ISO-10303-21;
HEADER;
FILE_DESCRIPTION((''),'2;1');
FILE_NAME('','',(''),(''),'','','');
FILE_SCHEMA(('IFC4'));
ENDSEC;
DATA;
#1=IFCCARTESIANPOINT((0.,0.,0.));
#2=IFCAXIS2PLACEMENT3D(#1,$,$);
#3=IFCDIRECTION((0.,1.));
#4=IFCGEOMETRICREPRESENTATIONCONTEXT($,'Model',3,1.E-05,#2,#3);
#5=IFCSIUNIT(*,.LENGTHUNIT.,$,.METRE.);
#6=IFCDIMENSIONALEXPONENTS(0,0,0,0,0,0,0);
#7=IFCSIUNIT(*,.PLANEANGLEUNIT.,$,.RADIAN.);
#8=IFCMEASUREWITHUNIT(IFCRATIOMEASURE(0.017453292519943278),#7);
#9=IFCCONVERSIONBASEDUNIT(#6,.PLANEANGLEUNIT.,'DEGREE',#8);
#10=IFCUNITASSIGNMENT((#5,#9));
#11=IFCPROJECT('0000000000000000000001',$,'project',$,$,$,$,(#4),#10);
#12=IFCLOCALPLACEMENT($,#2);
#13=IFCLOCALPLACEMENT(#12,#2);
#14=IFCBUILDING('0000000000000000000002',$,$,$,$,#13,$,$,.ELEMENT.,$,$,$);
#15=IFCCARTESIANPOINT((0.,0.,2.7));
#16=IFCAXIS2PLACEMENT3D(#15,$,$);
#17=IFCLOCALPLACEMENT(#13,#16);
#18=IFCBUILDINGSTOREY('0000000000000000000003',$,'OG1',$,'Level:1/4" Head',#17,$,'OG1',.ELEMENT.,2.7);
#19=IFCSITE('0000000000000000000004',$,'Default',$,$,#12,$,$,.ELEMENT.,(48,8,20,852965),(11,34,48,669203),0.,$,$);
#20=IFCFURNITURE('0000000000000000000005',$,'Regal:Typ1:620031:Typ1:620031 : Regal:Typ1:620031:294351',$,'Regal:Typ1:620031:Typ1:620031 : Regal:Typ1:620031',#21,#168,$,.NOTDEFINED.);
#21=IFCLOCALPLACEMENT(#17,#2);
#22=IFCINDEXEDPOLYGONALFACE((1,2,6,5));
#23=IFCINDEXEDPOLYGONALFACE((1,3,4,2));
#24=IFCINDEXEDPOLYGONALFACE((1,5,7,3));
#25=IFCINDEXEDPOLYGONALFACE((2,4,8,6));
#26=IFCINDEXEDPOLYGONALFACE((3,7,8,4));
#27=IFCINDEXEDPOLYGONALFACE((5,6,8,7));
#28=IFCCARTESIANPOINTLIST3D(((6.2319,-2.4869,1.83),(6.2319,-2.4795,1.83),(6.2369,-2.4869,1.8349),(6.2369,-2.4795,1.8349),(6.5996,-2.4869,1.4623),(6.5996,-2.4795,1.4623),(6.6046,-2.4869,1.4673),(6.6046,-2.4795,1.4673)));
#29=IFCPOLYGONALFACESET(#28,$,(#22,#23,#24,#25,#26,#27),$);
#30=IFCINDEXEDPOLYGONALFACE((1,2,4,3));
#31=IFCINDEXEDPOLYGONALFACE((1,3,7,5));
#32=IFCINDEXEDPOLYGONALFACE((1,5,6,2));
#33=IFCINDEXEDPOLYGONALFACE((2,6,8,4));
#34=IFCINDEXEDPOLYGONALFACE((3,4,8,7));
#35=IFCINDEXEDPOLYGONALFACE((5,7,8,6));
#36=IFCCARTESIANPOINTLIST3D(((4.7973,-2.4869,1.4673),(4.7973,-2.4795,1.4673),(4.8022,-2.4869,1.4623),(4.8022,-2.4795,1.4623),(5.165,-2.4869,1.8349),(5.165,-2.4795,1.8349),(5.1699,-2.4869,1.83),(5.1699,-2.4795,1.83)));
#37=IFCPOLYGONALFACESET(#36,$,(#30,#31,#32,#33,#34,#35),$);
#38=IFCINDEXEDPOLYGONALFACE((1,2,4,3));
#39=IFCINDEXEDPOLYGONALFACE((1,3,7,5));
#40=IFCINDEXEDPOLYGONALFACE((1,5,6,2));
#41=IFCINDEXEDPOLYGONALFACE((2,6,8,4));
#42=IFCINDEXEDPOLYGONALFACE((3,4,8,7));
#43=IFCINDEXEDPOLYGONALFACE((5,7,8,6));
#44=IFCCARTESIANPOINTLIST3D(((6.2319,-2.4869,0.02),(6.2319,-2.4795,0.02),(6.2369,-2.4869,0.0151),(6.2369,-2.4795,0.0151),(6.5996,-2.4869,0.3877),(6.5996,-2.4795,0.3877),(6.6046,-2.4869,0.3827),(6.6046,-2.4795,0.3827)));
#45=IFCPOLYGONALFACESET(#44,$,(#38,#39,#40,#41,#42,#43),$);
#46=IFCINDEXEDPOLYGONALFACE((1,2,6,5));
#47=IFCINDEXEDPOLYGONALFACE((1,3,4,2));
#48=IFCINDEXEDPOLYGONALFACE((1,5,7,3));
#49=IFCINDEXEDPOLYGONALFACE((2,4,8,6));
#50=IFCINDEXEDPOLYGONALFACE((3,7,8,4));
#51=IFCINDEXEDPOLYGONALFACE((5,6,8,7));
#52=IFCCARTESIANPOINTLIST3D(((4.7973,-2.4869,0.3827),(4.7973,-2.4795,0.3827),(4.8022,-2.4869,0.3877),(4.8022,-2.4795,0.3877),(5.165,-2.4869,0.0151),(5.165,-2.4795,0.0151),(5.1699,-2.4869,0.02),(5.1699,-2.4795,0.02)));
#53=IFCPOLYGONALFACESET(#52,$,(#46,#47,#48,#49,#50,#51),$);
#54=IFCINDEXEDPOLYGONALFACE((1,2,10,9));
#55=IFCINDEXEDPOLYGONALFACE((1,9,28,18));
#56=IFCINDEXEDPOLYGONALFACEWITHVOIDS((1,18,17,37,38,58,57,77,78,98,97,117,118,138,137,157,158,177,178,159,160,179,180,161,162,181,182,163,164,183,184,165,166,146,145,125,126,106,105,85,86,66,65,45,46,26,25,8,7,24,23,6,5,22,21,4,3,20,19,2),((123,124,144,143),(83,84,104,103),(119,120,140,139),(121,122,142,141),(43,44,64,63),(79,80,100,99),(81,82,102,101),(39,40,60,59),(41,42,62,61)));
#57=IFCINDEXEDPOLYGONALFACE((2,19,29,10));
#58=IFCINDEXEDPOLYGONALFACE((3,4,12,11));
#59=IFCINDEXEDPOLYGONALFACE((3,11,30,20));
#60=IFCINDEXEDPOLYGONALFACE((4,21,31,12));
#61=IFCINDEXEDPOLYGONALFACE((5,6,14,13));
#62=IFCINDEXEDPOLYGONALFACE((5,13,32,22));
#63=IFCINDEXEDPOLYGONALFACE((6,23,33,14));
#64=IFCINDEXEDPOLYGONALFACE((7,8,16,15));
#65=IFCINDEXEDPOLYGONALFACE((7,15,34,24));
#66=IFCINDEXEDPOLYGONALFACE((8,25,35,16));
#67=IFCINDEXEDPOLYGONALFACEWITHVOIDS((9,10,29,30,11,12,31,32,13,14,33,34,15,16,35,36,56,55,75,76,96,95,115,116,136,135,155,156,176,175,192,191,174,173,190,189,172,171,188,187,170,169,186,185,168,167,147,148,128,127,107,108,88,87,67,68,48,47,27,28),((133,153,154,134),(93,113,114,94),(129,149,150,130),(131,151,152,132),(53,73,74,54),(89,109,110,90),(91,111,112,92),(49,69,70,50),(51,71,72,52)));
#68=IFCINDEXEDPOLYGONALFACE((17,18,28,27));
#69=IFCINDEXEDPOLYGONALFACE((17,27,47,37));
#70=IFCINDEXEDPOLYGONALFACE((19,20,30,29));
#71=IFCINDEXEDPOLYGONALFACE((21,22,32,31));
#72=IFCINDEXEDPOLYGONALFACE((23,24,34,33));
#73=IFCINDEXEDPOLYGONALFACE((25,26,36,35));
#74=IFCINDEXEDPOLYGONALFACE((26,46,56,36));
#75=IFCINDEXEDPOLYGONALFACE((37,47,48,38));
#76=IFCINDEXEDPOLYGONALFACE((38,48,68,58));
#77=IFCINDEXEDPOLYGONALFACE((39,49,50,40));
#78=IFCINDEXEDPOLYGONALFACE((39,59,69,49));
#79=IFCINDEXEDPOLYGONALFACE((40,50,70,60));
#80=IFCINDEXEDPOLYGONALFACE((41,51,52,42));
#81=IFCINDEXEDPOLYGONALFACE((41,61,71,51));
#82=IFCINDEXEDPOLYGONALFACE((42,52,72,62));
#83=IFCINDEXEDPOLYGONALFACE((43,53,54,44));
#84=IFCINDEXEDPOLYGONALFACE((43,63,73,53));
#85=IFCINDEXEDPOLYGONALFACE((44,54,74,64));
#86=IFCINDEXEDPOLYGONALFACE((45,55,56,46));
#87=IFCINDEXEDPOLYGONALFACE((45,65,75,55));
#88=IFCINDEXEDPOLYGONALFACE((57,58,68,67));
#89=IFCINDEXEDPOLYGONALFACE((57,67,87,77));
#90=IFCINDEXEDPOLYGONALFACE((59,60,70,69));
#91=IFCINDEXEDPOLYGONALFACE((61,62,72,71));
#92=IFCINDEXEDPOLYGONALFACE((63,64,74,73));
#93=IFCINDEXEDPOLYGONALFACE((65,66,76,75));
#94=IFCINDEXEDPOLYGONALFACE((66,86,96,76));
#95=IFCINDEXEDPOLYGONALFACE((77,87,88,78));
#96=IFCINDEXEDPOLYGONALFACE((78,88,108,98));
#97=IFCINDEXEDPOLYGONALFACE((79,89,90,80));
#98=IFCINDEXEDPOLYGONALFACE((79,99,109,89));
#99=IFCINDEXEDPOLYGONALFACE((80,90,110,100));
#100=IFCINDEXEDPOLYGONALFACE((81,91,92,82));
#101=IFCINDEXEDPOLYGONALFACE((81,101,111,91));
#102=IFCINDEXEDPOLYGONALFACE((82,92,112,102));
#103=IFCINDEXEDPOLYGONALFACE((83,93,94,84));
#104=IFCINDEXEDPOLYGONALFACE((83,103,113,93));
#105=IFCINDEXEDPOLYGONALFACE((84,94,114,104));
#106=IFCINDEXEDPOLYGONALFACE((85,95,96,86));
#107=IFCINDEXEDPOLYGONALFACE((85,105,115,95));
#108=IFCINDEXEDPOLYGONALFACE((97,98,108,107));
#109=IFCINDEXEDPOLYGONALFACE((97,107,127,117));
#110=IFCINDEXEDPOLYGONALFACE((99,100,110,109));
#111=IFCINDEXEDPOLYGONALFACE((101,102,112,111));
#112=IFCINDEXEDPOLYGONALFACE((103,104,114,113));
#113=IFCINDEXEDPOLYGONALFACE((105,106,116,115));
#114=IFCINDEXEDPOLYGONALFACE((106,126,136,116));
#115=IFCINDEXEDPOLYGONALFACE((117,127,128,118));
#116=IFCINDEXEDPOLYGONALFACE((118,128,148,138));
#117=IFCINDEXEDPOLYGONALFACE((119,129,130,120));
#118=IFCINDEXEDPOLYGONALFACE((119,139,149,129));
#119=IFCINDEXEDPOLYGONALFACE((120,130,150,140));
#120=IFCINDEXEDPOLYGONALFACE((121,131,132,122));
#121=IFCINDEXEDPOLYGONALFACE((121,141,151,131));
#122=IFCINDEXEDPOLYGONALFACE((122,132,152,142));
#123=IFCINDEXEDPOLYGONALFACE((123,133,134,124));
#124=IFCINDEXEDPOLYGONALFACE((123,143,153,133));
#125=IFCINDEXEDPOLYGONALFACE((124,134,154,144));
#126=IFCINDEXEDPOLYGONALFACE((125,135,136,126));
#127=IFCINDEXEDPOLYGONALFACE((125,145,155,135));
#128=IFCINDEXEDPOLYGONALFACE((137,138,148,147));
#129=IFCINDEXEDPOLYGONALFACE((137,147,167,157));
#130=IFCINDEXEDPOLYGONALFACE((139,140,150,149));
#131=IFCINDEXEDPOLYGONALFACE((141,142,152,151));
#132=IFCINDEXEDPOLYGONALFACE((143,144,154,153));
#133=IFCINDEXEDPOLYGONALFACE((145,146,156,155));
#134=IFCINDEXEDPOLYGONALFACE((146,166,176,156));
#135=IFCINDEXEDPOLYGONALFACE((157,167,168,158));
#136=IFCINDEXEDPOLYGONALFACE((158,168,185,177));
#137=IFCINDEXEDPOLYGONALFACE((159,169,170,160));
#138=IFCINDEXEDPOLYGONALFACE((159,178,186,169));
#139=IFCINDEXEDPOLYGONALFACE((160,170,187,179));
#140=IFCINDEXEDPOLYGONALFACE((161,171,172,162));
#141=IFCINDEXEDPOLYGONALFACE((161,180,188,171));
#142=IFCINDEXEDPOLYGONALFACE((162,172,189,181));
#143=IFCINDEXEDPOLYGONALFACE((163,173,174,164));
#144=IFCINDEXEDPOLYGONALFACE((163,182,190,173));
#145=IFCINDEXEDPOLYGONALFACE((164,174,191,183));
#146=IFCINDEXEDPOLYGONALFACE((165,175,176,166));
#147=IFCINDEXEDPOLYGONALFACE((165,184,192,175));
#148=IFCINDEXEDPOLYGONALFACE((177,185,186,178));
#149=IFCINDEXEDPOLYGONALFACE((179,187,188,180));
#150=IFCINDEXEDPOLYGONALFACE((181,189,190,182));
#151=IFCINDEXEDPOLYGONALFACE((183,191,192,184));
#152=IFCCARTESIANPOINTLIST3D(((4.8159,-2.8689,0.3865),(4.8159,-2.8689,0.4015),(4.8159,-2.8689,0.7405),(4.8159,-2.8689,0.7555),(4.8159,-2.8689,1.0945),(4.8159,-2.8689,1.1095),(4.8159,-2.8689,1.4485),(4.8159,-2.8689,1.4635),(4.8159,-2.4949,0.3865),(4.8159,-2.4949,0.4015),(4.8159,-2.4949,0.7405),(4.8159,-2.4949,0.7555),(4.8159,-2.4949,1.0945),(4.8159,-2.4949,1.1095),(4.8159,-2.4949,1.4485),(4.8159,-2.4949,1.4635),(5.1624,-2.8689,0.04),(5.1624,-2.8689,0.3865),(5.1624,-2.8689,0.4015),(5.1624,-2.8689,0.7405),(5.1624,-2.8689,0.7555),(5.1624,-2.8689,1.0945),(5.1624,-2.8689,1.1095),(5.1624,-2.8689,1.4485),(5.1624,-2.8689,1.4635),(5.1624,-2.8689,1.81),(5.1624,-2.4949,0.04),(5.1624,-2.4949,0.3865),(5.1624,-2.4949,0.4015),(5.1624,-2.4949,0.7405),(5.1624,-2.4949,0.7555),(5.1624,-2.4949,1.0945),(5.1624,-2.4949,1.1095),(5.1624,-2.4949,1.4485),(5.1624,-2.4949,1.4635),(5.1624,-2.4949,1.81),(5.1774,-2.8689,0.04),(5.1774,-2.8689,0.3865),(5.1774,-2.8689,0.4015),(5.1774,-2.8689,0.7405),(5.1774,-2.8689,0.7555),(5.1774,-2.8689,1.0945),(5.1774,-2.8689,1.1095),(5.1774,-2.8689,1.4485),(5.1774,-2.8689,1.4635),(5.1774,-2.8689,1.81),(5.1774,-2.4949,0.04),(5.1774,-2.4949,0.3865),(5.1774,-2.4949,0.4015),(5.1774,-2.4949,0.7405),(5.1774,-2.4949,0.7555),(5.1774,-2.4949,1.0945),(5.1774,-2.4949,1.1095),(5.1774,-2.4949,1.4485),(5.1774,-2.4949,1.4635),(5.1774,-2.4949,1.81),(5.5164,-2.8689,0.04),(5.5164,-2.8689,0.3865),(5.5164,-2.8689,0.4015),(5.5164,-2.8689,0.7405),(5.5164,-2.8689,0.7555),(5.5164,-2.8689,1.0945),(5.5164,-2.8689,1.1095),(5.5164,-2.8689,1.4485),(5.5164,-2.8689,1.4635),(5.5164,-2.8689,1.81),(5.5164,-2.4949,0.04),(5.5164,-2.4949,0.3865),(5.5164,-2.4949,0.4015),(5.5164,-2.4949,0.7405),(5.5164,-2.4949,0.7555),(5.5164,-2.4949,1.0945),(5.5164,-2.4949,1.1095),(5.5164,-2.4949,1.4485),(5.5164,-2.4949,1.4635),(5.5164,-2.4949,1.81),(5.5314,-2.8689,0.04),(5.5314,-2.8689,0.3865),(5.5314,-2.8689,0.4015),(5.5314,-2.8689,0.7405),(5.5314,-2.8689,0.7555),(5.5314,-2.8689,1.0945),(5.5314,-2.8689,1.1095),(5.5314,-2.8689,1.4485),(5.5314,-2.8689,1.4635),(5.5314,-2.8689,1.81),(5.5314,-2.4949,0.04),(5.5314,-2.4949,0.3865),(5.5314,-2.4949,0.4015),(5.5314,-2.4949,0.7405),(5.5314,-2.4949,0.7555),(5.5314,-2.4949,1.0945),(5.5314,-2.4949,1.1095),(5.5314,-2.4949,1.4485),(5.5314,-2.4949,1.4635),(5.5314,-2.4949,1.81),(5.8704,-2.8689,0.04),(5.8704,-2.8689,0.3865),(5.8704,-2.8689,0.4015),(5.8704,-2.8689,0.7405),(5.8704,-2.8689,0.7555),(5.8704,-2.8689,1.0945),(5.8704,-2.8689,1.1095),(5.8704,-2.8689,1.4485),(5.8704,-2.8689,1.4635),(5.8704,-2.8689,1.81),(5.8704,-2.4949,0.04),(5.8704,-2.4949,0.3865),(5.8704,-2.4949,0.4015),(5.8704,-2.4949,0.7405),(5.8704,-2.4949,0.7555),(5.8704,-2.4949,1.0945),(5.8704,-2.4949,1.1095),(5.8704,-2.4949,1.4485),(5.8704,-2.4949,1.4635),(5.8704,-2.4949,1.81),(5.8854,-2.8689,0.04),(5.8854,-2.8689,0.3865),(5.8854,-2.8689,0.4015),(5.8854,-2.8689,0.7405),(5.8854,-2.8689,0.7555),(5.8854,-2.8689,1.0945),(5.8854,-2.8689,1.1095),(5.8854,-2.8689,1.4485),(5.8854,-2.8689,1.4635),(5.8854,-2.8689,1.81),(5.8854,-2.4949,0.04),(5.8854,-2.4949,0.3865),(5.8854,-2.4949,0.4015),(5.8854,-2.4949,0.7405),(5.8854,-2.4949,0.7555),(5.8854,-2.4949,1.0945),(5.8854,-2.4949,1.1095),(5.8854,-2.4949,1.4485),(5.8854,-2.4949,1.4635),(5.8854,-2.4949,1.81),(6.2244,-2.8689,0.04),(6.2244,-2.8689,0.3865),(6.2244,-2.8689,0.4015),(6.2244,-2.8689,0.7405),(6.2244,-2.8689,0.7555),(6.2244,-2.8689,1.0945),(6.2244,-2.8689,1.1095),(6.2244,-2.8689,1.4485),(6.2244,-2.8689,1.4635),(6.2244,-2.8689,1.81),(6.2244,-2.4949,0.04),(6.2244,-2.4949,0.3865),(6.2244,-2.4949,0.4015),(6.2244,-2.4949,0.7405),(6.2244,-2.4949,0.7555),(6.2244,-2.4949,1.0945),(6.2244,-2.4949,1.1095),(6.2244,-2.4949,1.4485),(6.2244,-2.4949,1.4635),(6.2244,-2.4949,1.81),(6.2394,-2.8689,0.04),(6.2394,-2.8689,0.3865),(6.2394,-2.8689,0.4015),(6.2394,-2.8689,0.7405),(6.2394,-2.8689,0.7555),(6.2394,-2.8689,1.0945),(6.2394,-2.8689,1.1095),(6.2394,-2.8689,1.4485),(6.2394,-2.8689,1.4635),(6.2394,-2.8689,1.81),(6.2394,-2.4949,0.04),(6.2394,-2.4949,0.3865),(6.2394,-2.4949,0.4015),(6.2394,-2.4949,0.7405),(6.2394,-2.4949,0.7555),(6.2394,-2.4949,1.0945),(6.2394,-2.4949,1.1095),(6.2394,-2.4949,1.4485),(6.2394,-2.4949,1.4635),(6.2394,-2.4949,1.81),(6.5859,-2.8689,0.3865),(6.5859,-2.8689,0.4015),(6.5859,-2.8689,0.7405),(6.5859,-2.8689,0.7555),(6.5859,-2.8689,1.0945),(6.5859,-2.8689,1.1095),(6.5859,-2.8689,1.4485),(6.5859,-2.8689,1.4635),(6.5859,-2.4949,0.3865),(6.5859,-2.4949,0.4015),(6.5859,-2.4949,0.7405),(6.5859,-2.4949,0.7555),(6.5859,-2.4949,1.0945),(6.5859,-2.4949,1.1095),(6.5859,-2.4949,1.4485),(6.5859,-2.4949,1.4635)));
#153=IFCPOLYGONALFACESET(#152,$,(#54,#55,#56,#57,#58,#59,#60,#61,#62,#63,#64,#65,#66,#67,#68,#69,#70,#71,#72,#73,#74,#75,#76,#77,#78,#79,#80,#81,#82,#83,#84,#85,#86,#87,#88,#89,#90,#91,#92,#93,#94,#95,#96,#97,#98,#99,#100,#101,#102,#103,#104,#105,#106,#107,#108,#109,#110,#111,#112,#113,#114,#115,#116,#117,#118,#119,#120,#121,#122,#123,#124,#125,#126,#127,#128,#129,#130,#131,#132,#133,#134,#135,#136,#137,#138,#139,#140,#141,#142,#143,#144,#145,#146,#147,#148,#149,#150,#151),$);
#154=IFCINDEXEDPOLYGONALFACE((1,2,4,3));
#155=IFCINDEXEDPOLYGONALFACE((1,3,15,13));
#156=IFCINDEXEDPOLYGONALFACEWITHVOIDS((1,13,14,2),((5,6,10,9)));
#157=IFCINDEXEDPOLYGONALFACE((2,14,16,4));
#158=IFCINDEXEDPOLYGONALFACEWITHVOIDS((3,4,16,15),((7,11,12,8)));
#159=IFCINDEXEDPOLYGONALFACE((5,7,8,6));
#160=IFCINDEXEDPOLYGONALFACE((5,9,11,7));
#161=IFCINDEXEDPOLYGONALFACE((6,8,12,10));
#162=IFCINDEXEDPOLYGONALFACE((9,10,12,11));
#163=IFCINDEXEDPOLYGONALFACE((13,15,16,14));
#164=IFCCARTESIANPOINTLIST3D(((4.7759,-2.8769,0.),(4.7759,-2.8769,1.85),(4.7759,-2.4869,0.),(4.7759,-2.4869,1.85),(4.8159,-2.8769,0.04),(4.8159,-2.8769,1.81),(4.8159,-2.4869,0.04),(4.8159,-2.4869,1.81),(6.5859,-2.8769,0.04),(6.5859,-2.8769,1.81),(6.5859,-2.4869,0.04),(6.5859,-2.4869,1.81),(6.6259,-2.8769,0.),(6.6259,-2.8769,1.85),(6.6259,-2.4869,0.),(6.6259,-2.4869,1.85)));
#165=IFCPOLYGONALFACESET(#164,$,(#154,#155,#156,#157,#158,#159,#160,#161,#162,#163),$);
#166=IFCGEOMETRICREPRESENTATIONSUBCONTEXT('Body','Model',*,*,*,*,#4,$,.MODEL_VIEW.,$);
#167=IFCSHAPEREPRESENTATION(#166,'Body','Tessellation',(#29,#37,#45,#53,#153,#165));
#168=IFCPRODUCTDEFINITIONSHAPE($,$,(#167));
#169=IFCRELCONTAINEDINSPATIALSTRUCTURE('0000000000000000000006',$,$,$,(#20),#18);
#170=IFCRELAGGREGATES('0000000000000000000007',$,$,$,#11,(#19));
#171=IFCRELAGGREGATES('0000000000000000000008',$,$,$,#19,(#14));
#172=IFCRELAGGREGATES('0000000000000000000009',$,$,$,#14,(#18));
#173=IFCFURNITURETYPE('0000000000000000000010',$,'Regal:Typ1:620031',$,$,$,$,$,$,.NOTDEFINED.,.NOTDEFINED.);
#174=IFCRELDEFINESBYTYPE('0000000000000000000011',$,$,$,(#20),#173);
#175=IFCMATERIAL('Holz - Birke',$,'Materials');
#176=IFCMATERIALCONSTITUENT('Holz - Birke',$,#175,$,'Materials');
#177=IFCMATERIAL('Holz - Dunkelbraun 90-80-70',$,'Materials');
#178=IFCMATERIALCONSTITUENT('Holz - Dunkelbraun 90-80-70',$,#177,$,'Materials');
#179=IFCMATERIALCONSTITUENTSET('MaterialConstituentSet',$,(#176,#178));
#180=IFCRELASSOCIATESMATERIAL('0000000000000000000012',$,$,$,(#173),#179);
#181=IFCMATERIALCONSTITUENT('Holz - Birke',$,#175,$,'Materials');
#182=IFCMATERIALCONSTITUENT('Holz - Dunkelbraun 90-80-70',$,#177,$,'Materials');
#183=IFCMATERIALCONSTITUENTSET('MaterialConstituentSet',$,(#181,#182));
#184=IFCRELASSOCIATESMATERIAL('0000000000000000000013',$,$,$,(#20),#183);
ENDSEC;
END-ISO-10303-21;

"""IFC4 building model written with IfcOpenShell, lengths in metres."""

from ifc_helpers import new_model, entity, si_unit, converted_unit, direction, frame, origin, place, context, subcontext, project, spatial, indexed_curve, outline, extrude, source, transform, mapped, material, constituent, constituent_set, type_object, type_shapes, element, save


model = new_model("IFC4")

# Units and contexts
model_context = context("Model", 3, precision=1e-05, world=origin(), true_north=direction((0.0, 1.0)))
body_context = subcontext(model_context, "Body", "Model", "MODEL_VIEW")
ifc_project = project(units=[si_unit("LENGTHUNIT", "METRE"), converted_unit("PLANEANGLEUNIT", "DEGREE", entity("IfcRatioMeasure", 0.017453292519943278), si_unit("PLANEANGLEUNIT", "RADIAN"), dimensions=[0, 0, 0, 0, 0, 0, 0])], contexts=[model_context])

# Site, building, storey
site_placement = place(None, origin())
site = spatial("IfcSite", under=ifc_project, at=site_placement, Name="Default", CompositionType="ELEMENT", RefLatitude=(48, 8, 20, 852965), RefLongitude=(11, 34, 48, 669203), RefElevation=0.0)
building_placement = place(site_placement, origin())
building = spatial("IfcBuilding", under=site, at=building_placement, CompositionType="ELEMENT")
storey_placement = place(building_placement, frame((0.0, 0.0, 2.7)))
storey = spatial("IfcBuildingStorey", under=building, at=storey_placement, Name="OG1", ObjectType="Level:1/4\" Head", LongName="OG1", CompositionType="ELEMENT", Elevation=2.7)

# Shared definitions
ifc_material_1 = material(Name="Holz - Birke", Category="Materials")

# Furniture
ifc_material_2 = material(Name="Holz - Dunkelbraun 90-80-70", Category="Materials")
ifc_constituent_1 = constituent(ifc_material_1, Name="Holz - Birke", Category="Materials")
ifc_constituent_2 = constituent(ifc_material_2, Name="Holz - Dunkelbraun 90-80-70", Category="Materials")
ifc_constituent_set_1 = constituent_set(constituents=[ifc_constituent_1, ifc_constituent_2], Name="MaterialConstituentSet")
ifc_constituent_3 = constituent(ifc_material_1, Name="Holz - Birke", Category="Materials")
ifc_constituent_4 = constituent(ifc_material_2, Name="Holz - Dunkelbraun 90-80-70", Category="Materials")
ifc_constituent_set_2 = constituent_set(constituents=[ifc_constituent_3, ifc_constituent_4], Name="MaterialConstituentSet")
furniture_type_1 = type_object("IfcFurnitureType", Name="Regal:Typ1:620031", AssemblyPlace="NOTDEFINED", PredefinedType="NOTDEFINED", material=ifc_constituent_set_2)
shared_shape_1 = source(origin(), body_context, "Body", "SweptSolid", [
    extrude(outline(indexed_curve([(-0.0035, -0.0037), (0.0035, -0.0037), (0.0035, 0.0037), (-0.0035, 0.0037), (-0.0035, -0.0037)], self_intersect=False)), frame((6.6021, -2.4832, 4.1648), z_axis=(-0.707107, 0.0, 0.707107), x_axis=(-0.707107, 0.0, -0.707107)), (0.0, 0.0, 1.0), 0.52),
    extrude(outline(indexed_curve([(-0.0035, -0.0037), (0.0035, -0.0037), (0.0035, 0.0037), (-0.0035, 0.0037), (-0.0035, -0.0037)], self_intersect=False)), frame((4.7998, -2.4832, 4.1648), z_axis=(0.707107, 0.0, 0.707107), x_axis=(-0.707107, 0.0, 0.707107)), (0.0, 0.0, 1.0), 0.52),
    extrude(outline(indexed_curve([(-0.0035, -0.0037), (0.0035, -0.0037), (0.0035, 0.0037), (-0.0035, 0.0037), (-0.0035, -0.0037)], self_intersect=False)), frame((6.2344, -2.4832, 2.7175), z_axis=(0.707107, 0.0, 0.707107), x_axis=(-0.707107, 0.0, 0.707107)), (0.0, 0.0, 1.0), 0.52),
    extrude(outline(indexed_curve([(-0.0035, -0.0037), (0.0035, -0.0037), (0.0035, 0.0037), (-0.0035, 0.0037), (-0.0035, -0.0037)], self_intersect=False)), frame((5.1675, -2.4832, 2.7175), z_axis=(-0.707107, 0.0, 0.707107), x_axis=(-0.707107, 0.0, -0.707107)), (0.0, 0.0, 1.0), 0.52),
    extrude(outline(indexed_curve([(-0.5385, -0.885), (-0.5235, -0.885), (-0.5235, -0.5385), (-0.1845, -0.5385), (-0.1845, -0.885), (-0.1695, -0.885), (-0.1695, -0.5385), (0.1695, -0.5385), (0.1695, -0.885), (0.1845, -0.885), (0.1845, -0.5385), (0.5235, -0.5385), (0.5235, -0.885), (0.5385, -0.885), (0.5385, -0.5385), (0.885, -0.5385), (0.885, -0.5235), (0.5385, -0.5235), (0.5385, -0.1845), (0.885, -0.1845), (0.885, -0.1695), (0.5385, -0.1695), (0.5385, 0.1695), (0.885, 0.1695), (0.885, 0.1845), (0.5385, 0.1845), (0.5385, 0.5235), (0.885, 0.5235), (0.885, 0.5385), (0.5385, 0.5385), (0.5385, 0.885), (0.5235, 0.885), (0.5235, 0.5385), (0.1845, 0.5385), (0.1845, 0.885), (0.1695, 0.885), (0.1695, 0.5385), (-0.1695, 0.5385), (-0.1695, 0.885), (-0.1845, 0.885), (-0.1845, 0.5385), (-0.5235, 0.5385), (-0.5235, 0.885), (-0.5385, 0.885), (-0.5385, 0.5385), (-0.885, 0.5385), (-0.885, 0.5235), (-0.5385, 0.5235), (-0.5385, 0.1845), (-0.885, 0.1845), (-0.885, 0.1695), (-0.5385, 0.1695), (-0.5385, -0.1695), (-0.885, -0.1695), (-0.885, -0.1845), (-0.5385, -0.1845), (-0.5385, -0.5235), (-0.885, -0.5235), (-0.885, -0.5385), (-0.5385, -0.5385), (-0.5385, -0.885)], self_intersect=False), holes=[indexed_curve([(-0.5235, -0.5235), (-0.5235, -0.1845), (-0.1845, -0.1845), (-0.1845, -0.5235), (-0.5235, -0.5235)], self_intersect=False), indexed_curve([(0.1695, -0.1845), (0.1695, -0.5235), (-0.1695, -0.5235), (-0.1695, -0.1845), (0.1695, -0.1845)], self_intersect=False), indexed_curve([(0.5235, -0.1845), (0.5235, -0.5235), (0.1845, -0.5235), (0.1845, -0.1845), (0.5235, -0.1845)], self_intersect=False), indexed_curve([(0.5235, -0.1695), (0.1845, -0.1695), (0.1845, 0.1695), (0.5235, 0.1695), (0.5235, -0.1695)], self_intersect=False), indexed_curve([(0.1695, -0.1695), (-0.1695, -0.1695), (-0.1695, 0.1695), (0.1695, 0.1695), (0.1695, -0.1695)], self_intersect=False), indexed_curve([(-0.1845, -0.1695), (-0.5235, -0.1695), (-0.5235, 0.1695), (-0.1845, 0.1695), (-0.1845, -0.1695)], self_intersect=False), indexed_curve([(-0.1845, 0.5235), (-0.1845, 0.1845), (-0.5235, 0.1845), (-0.5235, 0.5235), (-0.1845, 0.5235)], self_intersect=False), indexed_curve([(0.1695, 0.5235), (0.1695, 0.1845), (-0.1695, 0.1845), (-0.1695, 0.5235), (0.1695, 0.5235)], self_intersect=False), indexed_curve([(0.5235, 0.5235), (0.5235, 0.1845), (0.1845, 0.1845), (0.1845, 0.5235), (0.5235, 0.5235)], self_intersect=False)]), frame((5.7009, -2.8689, 3.625), z_axis=(0.0, 1.0, 0.0), x_axis=(1.0, 0.0, 0.0)), (0.0, 0.0, 1.0), 0.374),
    extrude(outline(indexed_curve([(-0.925, -0.925), (0.925, -0.925), (0.925, 0.925), (-0.925, 0.925), (-0.925, -0.925)], self_intersect=False), holes=[indexed_curve([(0.885, 0.885), (0.885, -0.885), (-0.885, -0.885), (-0.885, 0.885), (0.885, 0.885)], self_intersect=False)]), frame((5.7009, -2.8769, 3.625), z_axis=(0.0, 1.0, 0.0), x_axis=(-1.0, 0.0, 0.0)), (0.0, 0.0, 1.0), 0.39),
])
type_shapes(furniture_type_1, [shared_shape_1])
furniture_1_placement = place(storey_placement, frame((0.0, 0.0, -2.7)))
element("IfcFurniture", 1, at=furniture_1_placement, inside=storey, type_object=furniture_type_1, material=ifc_constituent_set_1, Name="Regal:Typ1:620031:Typ1:620031 : Regal:Typ1:620031:294351", ObjectType="Regal:Typ1:620031:Typ1:620031 : Regal:Typ1:620031", PredefinedType="NOTDEFINED", context=body_context, shape_type="MappedRepresentation", body=[
    mapped(shared_shape_1, transform((0.0, 0.0, 0.0), scale=1.0)),
])

save(model, "model.ifc")
